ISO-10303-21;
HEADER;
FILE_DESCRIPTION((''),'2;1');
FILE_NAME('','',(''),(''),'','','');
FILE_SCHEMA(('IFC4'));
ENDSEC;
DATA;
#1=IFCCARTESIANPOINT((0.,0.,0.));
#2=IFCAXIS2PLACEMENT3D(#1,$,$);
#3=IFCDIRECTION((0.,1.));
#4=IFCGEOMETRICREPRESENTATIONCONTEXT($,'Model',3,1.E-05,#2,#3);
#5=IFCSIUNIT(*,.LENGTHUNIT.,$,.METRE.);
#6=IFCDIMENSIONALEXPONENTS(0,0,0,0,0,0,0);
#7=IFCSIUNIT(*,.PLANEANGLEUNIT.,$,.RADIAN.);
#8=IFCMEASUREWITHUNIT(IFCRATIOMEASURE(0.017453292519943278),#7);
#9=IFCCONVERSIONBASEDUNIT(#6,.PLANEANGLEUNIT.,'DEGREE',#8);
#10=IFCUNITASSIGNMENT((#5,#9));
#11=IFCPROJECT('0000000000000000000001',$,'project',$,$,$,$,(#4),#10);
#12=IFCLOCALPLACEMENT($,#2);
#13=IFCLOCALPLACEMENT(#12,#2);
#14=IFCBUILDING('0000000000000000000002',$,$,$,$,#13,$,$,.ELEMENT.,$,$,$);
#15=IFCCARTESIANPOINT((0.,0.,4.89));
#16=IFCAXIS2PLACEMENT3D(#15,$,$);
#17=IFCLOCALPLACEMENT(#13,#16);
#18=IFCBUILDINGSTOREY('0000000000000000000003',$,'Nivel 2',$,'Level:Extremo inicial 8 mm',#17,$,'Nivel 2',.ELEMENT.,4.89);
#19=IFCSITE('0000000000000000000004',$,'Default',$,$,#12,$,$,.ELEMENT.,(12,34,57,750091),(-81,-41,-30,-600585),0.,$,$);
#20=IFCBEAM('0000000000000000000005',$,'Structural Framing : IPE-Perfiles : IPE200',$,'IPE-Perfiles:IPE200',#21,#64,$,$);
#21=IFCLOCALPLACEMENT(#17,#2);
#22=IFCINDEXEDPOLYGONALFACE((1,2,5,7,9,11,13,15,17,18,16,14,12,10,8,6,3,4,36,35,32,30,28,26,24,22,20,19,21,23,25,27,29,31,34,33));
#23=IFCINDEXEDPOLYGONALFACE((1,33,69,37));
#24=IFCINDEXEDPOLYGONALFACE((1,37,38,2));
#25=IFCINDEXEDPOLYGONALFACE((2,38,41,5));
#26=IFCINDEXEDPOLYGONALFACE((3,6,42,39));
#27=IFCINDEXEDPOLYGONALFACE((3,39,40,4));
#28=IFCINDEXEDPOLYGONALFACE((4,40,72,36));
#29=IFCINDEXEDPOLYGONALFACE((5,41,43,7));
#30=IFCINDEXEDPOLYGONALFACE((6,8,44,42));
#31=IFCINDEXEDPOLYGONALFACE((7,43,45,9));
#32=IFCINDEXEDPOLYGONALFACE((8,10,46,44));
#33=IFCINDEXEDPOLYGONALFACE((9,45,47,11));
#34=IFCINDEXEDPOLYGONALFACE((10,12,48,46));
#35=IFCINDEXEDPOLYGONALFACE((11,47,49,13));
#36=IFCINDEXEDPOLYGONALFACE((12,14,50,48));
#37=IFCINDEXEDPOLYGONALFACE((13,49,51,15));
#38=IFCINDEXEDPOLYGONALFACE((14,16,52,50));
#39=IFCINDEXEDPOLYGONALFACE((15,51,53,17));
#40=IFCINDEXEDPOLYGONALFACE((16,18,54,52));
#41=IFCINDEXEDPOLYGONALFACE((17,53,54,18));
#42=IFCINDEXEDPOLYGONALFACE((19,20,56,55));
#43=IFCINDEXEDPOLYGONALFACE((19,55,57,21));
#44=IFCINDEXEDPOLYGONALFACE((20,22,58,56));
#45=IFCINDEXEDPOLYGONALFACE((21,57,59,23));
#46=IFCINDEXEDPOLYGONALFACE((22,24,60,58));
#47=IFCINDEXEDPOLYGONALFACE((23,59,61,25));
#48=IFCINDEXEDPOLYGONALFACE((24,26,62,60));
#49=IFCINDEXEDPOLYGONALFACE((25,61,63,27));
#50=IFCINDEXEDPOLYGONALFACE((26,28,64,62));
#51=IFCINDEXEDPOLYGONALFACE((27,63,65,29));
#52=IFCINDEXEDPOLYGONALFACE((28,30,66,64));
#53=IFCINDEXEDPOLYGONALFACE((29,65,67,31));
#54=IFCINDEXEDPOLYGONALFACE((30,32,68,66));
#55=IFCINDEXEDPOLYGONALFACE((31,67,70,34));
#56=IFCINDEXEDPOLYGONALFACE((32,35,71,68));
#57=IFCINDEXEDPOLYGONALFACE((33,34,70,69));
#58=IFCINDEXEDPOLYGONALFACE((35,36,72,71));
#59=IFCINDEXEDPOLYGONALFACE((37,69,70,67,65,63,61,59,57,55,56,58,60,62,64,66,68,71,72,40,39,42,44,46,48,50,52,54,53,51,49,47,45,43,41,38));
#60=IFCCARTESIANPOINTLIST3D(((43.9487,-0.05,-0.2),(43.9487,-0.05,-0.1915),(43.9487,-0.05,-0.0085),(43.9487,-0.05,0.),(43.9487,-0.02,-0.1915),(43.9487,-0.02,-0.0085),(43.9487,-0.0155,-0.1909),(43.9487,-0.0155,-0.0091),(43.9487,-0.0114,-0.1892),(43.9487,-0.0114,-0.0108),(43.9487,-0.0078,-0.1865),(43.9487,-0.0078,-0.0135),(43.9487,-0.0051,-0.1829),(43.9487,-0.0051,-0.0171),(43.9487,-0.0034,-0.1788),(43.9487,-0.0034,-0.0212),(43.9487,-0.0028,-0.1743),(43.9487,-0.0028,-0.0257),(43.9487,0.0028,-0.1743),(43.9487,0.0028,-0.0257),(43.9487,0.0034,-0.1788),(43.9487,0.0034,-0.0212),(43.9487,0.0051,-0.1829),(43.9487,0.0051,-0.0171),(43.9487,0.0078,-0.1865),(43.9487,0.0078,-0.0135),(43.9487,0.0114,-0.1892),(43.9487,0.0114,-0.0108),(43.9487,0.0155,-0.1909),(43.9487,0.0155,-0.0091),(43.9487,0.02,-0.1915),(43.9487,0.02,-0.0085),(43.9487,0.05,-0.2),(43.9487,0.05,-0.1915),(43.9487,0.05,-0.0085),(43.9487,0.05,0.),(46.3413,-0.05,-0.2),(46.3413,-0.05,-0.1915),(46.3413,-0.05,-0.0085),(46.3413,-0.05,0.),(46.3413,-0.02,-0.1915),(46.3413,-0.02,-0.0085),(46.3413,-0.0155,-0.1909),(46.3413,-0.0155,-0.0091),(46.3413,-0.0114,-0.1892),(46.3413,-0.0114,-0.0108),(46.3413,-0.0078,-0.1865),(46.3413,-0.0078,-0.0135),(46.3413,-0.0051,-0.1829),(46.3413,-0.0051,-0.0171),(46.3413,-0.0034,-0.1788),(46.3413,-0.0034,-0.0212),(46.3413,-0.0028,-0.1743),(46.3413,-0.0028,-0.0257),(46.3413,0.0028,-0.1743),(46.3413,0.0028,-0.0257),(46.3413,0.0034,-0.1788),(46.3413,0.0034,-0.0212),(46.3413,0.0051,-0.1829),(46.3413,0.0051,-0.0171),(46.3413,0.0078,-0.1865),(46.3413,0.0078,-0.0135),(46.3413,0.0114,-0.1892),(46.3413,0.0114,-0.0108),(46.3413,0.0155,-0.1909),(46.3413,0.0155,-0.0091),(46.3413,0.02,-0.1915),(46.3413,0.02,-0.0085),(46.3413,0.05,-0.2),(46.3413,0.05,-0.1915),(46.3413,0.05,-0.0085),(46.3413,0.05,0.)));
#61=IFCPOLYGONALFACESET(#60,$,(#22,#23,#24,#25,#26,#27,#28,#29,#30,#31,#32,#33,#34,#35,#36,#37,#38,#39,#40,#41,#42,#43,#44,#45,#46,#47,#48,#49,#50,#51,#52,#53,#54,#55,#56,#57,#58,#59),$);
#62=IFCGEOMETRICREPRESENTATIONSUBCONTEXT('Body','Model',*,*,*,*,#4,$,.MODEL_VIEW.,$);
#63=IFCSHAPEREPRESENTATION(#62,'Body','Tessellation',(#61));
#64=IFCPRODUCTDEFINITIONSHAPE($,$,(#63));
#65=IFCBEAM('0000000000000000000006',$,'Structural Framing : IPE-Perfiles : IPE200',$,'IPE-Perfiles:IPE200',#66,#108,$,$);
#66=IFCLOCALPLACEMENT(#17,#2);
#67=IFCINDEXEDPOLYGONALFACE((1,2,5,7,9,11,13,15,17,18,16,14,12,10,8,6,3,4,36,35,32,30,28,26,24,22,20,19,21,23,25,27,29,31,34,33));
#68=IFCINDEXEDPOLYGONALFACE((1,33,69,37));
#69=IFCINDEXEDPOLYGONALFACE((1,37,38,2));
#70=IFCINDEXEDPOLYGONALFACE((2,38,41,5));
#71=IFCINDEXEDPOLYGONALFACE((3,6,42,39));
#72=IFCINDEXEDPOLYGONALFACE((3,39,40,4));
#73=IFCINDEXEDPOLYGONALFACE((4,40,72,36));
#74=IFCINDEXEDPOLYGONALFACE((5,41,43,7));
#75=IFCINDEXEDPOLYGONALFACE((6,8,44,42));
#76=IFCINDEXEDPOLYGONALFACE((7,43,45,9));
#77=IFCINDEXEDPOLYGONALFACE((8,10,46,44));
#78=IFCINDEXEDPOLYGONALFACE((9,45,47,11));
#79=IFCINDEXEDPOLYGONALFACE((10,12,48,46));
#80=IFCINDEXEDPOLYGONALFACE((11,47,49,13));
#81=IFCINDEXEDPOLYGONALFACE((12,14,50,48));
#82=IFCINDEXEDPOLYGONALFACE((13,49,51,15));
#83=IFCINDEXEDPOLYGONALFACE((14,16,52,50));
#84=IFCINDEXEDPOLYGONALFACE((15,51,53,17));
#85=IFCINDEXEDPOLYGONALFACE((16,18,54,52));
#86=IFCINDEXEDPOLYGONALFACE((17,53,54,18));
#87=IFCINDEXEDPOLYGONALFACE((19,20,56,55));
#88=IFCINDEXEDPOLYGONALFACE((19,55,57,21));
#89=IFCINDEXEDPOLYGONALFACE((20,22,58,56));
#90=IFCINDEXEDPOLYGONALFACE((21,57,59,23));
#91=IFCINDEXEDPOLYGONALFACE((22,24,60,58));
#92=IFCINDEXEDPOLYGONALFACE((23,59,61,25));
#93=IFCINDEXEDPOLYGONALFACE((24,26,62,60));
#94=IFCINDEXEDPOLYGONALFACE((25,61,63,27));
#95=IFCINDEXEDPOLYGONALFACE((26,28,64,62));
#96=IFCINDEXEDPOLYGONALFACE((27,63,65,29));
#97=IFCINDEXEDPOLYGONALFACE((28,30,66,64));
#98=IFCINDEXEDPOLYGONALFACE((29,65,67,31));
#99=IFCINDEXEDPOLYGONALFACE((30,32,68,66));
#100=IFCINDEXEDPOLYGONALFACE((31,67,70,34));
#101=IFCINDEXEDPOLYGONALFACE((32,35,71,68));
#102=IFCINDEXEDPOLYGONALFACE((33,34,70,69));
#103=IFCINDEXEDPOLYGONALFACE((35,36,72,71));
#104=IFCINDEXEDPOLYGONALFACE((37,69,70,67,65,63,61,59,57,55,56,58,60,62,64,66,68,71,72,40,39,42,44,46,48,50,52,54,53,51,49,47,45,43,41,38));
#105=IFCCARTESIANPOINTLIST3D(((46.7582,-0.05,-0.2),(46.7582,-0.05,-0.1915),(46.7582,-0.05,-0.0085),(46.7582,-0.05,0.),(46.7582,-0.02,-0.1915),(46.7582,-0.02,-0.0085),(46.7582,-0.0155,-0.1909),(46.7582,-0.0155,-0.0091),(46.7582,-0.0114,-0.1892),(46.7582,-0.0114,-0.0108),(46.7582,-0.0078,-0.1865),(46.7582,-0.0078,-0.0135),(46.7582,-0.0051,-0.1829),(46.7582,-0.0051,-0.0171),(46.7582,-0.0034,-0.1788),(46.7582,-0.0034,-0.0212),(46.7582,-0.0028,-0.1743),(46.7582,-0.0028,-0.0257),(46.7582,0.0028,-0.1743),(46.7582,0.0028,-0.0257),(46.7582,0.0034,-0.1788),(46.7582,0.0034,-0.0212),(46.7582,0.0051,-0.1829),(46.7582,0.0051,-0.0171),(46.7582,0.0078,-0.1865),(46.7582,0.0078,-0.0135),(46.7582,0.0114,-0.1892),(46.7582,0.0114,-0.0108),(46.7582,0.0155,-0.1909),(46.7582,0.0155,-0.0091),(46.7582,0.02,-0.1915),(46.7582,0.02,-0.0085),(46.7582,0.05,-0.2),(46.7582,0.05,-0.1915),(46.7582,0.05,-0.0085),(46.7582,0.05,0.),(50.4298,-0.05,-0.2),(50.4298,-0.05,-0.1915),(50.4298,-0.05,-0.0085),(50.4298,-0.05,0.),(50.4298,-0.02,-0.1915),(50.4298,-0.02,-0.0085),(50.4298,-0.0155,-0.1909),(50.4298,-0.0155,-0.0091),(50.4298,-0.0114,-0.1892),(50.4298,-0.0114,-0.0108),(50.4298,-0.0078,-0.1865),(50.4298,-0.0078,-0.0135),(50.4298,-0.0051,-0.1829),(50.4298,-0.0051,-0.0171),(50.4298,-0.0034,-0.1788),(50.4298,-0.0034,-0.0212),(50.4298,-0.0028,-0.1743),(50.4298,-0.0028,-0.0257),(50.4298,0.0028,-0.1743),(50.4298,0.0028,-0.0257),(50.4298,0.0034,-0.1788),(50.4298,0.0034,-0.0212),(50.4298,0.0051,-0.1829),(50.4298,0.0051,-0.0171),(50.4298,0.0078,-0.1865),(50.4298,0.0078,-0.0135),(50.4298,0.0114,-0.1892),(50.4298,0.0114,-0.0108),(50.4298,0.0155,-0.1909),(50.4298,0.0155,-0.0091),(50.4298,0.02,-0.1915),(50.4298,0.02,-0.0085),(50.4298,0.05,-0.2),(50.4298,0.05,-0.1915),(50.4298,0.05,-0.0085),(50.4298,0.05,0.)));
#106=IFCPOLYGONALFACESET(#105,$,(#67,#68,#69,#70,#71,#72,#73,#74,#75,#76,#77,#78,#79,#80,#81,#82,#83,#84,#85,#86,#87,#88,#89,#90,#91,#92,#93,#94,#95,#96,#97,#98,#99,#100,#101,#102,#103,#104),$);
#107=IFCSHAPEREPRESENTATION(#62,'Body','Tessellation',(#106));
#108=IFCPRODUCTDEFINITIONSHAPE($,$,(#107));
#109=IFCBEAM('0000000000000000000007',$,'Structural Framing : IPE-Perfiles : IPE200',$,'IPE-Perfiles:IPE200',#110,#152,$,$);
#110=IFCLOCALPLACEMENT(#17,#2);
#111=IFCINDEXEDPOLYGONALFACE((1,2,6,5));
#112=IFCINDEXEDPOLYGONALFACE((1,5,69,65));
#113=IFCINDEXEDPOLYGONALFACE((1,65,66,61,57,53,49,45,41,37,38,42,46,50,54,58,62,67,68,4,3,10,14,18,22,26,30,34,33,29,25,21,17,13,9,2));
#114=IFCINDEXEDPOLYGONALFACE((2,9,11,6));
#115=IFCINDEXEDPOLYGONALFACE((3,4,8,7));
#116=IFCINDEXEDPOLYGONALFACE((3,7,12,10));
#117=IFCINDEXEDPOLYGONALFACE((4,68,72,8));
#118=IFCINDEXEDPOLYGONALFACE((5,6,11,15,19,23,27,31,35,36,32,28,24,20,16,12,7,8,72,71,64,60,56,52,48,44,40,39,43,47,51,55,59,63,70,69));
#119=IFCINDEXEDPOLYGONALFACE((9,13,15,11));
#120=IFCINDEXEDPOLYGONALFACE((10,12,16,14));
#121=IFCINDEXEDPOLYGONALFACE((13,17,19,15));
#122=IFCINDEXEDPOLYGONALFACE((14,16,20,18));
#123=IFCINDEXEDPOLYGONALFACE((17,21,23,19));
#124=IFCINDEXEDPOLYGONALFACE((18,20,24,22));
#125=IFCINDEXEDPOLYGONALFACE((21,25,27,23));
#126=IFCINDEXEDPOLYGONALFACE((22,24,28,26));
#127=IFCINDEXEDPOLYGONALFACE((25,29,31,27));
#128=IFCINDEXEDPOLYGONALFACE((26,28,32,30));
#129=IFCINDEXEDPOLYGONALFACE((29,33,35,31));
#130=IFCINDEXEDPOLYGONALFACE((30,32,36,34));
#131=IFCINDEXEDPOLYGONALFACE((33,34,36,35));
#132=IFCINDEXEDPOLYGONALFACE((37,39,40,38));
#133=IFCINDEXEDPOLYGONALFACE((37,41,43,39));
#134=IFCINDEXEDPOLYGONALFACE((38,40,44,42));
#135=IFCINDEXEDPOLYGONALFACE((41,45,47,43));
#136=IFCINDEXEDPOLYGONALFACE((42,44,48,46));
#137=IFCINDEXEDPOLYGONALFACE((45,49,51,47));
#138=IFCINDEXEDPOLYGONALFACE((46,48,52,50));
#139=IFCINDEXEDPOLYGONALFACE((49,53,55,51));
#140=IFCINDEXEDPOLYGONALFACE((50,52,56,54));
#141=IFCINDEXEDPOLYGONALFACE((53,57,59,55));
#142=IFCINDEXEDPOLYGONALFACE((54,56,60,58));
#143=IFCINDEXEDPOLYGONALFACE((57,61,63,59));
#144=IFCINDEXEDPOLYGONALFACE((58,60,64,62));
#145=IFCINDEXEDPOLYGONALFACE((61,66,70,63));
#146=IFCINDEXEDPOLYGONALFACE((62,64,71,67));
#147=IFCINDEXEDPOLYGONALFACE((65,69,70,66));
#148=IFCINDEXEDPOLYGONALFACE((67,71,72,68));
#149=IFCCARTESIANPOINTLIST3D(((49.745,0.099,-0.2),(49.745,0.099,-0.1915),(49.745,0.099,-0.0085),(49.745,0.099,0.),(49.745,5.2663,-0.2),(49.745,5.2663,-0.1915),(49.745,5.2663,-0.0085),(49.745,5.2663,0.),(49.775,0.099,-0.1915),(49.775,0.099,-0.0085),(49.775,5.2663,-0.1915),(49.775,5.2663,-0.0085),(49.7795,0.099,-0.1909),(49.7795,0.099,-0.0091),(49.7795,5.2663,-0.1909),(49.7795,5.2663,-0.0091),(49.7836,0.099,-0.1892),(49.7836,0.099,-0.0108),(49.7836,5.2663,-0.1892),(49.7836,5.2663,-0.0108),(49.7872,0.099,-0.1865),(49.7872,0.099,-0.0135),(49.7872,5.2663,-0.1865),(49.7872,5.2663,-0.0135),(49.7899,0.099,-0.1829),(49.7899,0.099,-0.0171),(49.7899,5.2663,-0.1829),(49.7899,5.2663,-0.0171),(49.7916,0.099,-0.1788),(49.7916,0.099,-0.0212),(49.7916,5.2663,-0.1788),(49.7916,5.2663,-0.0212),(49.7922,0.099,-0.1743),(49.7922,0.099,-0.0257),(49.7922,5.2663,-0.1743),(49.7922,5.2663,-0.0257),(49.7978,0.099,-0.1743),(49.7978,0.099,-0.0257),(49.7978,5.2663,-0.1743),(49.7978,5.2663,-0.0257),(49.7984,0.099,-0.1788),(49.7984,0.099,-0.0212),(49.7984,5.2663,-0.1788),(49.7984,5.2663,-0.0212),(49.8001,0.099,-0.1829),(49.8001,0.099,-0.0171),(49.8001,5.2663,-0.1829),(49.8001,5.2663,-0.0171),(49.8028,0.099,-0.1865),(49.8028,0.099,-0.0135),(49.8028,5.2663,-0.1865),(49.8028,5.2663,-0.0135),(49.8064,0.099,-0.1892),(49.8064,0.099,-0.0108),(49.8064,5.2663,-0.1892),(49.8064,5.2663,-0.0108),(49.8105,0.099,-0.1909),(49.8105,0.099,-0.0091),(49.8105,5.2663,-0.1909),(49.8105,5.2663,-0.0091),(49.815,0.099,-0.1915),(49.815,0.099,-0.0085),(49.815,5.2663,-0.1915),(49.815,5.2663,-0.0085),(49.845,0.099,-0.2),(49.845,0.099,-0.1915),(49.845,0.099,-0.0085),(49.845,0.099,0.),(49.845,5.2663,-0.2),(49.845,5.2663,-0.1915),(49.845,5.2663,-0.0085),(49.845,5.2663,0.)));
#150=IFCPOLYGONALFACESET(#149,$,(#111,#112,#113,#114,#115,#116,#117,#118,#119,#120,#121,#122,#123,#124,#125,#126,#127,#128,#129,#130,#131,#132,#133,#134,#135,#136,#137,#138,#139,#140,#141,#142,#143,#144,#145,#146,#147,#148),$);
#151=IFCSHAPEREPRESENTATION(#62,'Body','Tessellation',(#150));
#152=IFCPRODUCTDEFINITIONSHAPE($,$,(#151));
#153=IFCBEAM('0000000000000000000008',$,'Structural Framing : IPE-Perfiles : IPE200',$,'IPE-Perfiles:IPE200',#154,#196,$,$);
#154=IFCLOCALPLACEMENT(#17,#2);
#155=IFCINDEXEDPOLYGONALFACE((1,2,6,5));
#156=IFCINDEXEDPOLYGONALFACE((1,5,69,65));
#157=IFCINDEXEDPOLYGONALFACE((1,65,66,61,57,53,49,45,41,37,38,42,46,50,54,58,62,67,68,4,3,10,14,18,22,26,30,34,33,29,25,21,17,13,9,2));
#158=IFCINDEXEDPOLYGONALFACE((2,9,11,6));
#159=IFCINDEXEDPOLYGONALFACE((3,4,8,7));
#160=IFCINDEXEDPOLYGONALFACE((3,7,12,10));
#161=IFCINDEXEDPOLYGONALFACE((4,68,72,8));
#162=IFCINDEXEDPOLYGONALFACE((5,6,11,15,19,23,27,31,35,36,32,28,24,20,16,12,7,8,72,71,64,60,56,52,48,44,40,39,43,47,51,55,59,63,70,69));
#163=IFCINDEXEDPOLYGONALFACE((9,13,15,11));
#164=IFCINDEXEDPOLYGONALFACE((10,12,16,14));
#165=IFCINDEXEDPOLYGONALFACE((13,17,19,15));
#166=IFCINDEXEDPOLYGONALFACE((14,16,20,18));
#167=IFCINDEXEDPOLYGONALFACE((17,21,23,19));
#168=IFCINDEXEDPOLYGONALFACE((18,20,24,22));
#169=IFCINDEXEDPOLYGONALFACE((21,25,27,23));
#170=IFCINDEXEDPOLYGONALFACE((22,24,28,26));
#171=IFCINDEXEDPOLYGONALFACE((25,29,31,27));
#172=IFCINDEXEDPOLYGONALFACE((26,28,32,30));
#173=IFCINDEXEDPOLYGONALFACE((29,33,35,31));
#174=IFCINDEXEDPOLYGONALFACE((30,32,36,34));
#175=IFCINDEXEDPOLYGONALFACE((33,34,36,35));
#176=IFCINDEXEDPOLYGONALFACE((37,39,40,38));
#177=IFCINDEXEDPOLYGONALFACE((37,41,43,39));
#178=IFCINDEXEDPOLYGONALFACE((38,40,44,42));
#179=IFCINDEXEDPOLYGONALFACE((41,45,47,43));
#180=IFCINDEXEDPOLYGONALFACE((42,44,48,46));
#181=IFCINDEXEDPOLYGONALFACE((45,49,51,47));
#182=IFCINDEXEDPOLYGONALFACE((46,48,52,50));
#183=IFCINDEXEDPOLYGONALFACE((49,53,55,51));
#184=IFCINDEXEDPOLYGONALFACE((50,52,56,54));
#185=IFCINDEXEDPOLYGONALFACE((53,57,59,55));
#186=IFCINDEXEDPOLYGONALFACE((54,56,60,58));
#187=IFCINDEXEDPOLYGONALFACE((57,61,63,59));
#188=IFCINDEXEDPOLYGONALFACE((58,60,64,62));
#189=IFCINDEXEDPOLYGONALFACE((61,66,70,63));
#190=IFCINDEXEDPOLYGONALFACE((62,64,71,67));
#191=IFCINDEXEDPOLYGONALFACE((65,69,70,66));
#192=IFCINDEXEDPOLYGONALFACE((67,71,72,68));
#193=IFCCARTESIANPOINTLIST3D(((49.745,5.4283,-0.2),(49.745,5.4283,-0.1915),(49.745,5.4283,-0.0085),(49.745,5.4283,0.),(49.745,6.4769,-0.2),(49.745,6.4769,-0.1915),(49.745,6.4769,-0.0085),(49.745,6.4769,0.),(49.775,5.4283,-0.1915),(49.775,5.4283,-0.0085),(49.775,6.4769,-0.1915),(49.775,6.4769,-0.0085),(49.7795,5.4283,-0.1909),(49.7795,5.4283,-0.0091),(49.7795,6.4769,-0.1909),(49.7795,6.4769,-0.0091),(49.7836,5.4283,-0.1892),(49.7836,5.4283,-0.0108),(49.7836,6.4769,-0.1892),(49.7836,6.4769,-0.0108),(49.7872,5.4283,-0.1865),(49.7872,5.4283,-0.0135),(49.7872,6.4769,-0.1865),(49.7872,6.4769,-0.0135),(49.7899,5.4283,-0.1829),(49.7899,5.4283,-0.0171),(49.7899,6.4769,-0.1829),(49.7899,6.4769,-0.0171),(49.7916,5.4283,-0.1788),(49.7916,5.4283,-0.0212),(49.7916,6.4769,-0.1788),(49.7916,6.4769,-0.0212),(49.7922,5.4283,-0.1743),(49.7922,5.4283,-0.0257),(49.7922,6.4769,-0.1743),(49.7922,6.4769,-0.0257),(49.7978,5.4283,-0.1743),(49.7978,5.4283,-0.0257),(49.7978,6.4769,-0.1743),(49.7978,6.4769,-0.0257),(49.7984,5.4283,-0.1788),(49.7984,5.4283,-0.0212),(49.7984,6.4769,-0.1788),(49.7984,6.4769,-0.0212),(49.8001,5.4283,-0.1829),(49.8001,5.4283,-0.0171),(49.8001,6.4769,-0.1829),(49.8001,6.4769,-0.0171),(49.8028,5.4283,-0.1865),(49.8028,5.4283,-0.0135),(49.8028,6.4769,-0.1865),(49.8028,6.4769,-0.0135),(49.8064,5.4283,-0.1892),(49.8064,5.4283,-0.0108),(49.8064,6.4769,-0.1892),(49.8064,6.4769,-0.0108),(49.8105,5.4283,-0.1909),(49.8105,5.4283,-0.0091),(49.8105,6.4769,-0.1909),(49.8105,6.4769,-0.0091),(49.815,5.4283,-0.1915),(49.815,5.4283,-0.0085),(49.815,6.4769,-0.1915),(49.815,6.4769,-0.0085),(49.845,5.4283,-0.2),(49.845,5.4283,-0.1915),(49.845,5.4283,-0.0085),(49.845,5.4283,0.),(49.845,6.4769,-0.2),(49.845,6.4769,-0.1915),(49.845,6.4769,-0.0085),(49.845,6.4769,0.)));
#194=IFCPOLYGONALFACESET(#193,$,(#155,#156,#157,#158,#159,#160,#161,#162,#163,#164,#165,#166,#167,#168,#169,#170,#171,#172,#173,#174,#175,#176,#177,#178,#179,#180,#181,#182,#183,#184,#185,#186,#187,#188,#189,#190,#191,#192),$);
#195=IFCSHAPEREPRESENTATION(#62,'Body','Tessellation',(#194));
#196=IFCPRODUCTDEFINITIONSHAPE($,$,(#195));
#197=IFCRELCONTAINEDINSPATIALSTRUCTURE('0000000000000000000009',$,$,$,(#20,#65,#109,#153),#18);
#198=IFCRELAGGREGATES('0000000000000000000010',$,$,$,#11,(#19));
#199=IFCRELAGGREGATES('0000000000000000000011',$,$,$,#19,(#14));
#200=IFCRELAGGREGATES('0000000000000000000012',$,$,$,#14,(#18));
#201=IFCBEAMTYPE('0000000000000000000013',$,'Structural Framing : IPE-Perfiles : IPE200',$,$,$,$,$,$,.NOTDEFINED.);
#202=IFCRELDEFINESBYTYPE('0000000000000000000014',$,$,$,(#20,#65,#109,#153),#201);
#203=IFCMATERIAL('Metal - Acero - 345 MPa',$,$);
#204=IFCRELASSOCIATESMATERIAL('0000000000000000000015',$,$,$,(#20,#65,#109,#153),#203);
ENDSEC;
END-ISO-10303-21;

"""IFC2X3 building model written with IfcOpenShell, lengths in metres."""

from ifc_helpers import new_model, entity, si_unit, converted_unit, direction, frame, frame_2d, origin, place, context, subcontext, project, spatial, i_section, extrude, material, type_object, element, save


model = new_model("IFC2X3")

# Units and contexts
model_context = context("Model", 3, precision=1e-05, world=origin(), true_north=direction((0.0, 1.0)))
body_context = subcontext(model_context, "Body", "Model", "MODEL_VIEW")
ifc_project = project(units=[si_unit("LENGTHUNIT", "METRE"), converted_unit("PLANEANGLEUNIT", "DEGREE", entity("IfcRatioMeasure", 0.017453292519943278), si_unit("PLANEANGLEUNIT", "RADIAN"), dimensions=[0, 0, 0, 0, 0, 0, 0])], contexts=[model_context])

# Site, building, storey
site_placement = place(None, origin())
site = spatial("IfcSite", under=ifc_project, at=site_placement, Name="Default", CompositionType="ELEMENT", RefLatitude=(12, 34, 57, 750091), RefLongitude=(-81, -41, -30, -600585), RefElevation=0.0)
building_placement = place(site_placement, origin())
building = spatial("IfcBuilding", under=site, at=building_placement, CompositionType="ELEMENT")
storey_placement = place(building_placement, frame((0.0, 0.0, 4.89)))
storey = spatial("IfcBuildingStorey", under=building, at=storey_placement, Name="Nivel 2", ObjectType="Level:Extremo inicial 8 mm", LongName="Nivel 2", CompositionType="ELEMENT", Elevation=4.89)

# Shared definitions
ifc_material_1 = material(Name="Metal - Acero - 345 MPa")

# Beams
beam_type_1 = type_object("IfcBeamType", Name="Structural Framing : IPE-Perfiles : IPE200", PredefinedType="NOTDEFINED")
beam_1_placement = place(storey_placement, frame((43.935, 0.0, 0.0)))
element("IfcBeam", 1, at=beam_1_placement, inside=storey, type_object=beam_type_1, material=ifc_material_1, Name="Structural Framing : IPE-Perfiles : IPE200", ObjectType="IPE-Perfiles:IPE200", context=body_context, shape_type="SweptSolid", body=[
    extrude(i_section(OverallWidth=0.1, OverallDepth=0.2, WebThickness=0.0056, FlangeThickness=0.0085, FilletRadius=0.0172, at=frame_2d((0.0, 0.0), x_axis=(0.0, 1.0))), frame((0.0137, 0.0, -0.1), z_axis=(1.0, 0.0, 0.0), x_axis=(0.0, 0.0, -1.0)), (0.0, 0.0, 1.0), 2.3926),
])
beam_2_placement = place(storey_placement, frame((46.745, 0.0, 0.0)))
element("IfcBeam", 2, at=beam_2_placement, inside=storey, type_object=beam_type_1, material=ifc_material_1, Name="Structural Framing : IPE-Perfiles : IPE200", ObjectType="IPE-Perfiles:IPE200", context=body_context, shape_type="SweptSolid", body=[
    extrude(i_section(OverallWidth=0.1, OverallDepth=0.2, WebThickness=0.0056, FlangeThickness=0.0085, FilletRadius=0.0172, at=frame_2d((0.0, 0.0), x_axis=(0.0, 1.0))), frame((0.0132, 0.0, -0.1), z_axis=(1.0, 0.0, 0.0), x_axis=(0.0, 0.0, -1.0)), (0.0, 0.0, 1.0), 3.6716),
])
beam_3_placement = place(storey_placement, frame((49.795, 0.0988, 0.0), z_axis=(0.0, 0.0, 1.0), x_axis=(0.0, 1.0, 0.0)))
element("IfcBeam", 3, at=beam_3_placement, inside=storey, type_object=beam_type_1, material=ifc_material_1, Name="Structural Framing : IPE-Perfiles : IPE200", ObjectType="IPE-Perfiles:IPE200", context=body_context, shape_type="SweptSolid", body=[
    extrude(i_section(OverallWidth=0.1, OverallDepth=0.2, WebThickness=0.0056, FlangeThickness=0.0085, FilletRadius=0.0172, at=frame_2d((0.0, 0.0), x_axis=(0.0, 1.0))), frame((0.0002, 0.0, -0.1), z_axis=(1.0, 0.0, 0.0), x_axis=(0.0, 0.0, -1.0)), (0.0, 0.0, 1.0), 5.1673),
])
beam_4_placement = place(storey_placement, frame((49.795, 5.3471, 0.0), z_axis=(0.0, 0.0, 1.0), x_axis=(0.0, 1.0, 0.0)))
element("IfcBeam", 4, at=beam_4_placement, inside=storey, type_object=beam_type_1, material=ifc_material_1, Name="Structural Framing : IPE-Perfiles : IPE200", ObjectType="IPE-Perfiles:IPE200", context=body_context, shape_type="SweptSolid", body=[
    extrude(i_section(OverallWidth=0.1, OverallDepth=0.2, WebThickness=0.0056, FlangeThickness=0.0085, FilletRadius=0.0172, at=frame_2d((0.0, 0.0), x_axis=(0.0, 1.0))), frame((0.0811, 0.0, -0.1), z_axis=(1.0, 0.0, 0.0), x_axis=(0.0, 0.0, -1.0)), (0.0, 0.0, 1.0), 1.0486),
])

save(model, "model.ifc")
